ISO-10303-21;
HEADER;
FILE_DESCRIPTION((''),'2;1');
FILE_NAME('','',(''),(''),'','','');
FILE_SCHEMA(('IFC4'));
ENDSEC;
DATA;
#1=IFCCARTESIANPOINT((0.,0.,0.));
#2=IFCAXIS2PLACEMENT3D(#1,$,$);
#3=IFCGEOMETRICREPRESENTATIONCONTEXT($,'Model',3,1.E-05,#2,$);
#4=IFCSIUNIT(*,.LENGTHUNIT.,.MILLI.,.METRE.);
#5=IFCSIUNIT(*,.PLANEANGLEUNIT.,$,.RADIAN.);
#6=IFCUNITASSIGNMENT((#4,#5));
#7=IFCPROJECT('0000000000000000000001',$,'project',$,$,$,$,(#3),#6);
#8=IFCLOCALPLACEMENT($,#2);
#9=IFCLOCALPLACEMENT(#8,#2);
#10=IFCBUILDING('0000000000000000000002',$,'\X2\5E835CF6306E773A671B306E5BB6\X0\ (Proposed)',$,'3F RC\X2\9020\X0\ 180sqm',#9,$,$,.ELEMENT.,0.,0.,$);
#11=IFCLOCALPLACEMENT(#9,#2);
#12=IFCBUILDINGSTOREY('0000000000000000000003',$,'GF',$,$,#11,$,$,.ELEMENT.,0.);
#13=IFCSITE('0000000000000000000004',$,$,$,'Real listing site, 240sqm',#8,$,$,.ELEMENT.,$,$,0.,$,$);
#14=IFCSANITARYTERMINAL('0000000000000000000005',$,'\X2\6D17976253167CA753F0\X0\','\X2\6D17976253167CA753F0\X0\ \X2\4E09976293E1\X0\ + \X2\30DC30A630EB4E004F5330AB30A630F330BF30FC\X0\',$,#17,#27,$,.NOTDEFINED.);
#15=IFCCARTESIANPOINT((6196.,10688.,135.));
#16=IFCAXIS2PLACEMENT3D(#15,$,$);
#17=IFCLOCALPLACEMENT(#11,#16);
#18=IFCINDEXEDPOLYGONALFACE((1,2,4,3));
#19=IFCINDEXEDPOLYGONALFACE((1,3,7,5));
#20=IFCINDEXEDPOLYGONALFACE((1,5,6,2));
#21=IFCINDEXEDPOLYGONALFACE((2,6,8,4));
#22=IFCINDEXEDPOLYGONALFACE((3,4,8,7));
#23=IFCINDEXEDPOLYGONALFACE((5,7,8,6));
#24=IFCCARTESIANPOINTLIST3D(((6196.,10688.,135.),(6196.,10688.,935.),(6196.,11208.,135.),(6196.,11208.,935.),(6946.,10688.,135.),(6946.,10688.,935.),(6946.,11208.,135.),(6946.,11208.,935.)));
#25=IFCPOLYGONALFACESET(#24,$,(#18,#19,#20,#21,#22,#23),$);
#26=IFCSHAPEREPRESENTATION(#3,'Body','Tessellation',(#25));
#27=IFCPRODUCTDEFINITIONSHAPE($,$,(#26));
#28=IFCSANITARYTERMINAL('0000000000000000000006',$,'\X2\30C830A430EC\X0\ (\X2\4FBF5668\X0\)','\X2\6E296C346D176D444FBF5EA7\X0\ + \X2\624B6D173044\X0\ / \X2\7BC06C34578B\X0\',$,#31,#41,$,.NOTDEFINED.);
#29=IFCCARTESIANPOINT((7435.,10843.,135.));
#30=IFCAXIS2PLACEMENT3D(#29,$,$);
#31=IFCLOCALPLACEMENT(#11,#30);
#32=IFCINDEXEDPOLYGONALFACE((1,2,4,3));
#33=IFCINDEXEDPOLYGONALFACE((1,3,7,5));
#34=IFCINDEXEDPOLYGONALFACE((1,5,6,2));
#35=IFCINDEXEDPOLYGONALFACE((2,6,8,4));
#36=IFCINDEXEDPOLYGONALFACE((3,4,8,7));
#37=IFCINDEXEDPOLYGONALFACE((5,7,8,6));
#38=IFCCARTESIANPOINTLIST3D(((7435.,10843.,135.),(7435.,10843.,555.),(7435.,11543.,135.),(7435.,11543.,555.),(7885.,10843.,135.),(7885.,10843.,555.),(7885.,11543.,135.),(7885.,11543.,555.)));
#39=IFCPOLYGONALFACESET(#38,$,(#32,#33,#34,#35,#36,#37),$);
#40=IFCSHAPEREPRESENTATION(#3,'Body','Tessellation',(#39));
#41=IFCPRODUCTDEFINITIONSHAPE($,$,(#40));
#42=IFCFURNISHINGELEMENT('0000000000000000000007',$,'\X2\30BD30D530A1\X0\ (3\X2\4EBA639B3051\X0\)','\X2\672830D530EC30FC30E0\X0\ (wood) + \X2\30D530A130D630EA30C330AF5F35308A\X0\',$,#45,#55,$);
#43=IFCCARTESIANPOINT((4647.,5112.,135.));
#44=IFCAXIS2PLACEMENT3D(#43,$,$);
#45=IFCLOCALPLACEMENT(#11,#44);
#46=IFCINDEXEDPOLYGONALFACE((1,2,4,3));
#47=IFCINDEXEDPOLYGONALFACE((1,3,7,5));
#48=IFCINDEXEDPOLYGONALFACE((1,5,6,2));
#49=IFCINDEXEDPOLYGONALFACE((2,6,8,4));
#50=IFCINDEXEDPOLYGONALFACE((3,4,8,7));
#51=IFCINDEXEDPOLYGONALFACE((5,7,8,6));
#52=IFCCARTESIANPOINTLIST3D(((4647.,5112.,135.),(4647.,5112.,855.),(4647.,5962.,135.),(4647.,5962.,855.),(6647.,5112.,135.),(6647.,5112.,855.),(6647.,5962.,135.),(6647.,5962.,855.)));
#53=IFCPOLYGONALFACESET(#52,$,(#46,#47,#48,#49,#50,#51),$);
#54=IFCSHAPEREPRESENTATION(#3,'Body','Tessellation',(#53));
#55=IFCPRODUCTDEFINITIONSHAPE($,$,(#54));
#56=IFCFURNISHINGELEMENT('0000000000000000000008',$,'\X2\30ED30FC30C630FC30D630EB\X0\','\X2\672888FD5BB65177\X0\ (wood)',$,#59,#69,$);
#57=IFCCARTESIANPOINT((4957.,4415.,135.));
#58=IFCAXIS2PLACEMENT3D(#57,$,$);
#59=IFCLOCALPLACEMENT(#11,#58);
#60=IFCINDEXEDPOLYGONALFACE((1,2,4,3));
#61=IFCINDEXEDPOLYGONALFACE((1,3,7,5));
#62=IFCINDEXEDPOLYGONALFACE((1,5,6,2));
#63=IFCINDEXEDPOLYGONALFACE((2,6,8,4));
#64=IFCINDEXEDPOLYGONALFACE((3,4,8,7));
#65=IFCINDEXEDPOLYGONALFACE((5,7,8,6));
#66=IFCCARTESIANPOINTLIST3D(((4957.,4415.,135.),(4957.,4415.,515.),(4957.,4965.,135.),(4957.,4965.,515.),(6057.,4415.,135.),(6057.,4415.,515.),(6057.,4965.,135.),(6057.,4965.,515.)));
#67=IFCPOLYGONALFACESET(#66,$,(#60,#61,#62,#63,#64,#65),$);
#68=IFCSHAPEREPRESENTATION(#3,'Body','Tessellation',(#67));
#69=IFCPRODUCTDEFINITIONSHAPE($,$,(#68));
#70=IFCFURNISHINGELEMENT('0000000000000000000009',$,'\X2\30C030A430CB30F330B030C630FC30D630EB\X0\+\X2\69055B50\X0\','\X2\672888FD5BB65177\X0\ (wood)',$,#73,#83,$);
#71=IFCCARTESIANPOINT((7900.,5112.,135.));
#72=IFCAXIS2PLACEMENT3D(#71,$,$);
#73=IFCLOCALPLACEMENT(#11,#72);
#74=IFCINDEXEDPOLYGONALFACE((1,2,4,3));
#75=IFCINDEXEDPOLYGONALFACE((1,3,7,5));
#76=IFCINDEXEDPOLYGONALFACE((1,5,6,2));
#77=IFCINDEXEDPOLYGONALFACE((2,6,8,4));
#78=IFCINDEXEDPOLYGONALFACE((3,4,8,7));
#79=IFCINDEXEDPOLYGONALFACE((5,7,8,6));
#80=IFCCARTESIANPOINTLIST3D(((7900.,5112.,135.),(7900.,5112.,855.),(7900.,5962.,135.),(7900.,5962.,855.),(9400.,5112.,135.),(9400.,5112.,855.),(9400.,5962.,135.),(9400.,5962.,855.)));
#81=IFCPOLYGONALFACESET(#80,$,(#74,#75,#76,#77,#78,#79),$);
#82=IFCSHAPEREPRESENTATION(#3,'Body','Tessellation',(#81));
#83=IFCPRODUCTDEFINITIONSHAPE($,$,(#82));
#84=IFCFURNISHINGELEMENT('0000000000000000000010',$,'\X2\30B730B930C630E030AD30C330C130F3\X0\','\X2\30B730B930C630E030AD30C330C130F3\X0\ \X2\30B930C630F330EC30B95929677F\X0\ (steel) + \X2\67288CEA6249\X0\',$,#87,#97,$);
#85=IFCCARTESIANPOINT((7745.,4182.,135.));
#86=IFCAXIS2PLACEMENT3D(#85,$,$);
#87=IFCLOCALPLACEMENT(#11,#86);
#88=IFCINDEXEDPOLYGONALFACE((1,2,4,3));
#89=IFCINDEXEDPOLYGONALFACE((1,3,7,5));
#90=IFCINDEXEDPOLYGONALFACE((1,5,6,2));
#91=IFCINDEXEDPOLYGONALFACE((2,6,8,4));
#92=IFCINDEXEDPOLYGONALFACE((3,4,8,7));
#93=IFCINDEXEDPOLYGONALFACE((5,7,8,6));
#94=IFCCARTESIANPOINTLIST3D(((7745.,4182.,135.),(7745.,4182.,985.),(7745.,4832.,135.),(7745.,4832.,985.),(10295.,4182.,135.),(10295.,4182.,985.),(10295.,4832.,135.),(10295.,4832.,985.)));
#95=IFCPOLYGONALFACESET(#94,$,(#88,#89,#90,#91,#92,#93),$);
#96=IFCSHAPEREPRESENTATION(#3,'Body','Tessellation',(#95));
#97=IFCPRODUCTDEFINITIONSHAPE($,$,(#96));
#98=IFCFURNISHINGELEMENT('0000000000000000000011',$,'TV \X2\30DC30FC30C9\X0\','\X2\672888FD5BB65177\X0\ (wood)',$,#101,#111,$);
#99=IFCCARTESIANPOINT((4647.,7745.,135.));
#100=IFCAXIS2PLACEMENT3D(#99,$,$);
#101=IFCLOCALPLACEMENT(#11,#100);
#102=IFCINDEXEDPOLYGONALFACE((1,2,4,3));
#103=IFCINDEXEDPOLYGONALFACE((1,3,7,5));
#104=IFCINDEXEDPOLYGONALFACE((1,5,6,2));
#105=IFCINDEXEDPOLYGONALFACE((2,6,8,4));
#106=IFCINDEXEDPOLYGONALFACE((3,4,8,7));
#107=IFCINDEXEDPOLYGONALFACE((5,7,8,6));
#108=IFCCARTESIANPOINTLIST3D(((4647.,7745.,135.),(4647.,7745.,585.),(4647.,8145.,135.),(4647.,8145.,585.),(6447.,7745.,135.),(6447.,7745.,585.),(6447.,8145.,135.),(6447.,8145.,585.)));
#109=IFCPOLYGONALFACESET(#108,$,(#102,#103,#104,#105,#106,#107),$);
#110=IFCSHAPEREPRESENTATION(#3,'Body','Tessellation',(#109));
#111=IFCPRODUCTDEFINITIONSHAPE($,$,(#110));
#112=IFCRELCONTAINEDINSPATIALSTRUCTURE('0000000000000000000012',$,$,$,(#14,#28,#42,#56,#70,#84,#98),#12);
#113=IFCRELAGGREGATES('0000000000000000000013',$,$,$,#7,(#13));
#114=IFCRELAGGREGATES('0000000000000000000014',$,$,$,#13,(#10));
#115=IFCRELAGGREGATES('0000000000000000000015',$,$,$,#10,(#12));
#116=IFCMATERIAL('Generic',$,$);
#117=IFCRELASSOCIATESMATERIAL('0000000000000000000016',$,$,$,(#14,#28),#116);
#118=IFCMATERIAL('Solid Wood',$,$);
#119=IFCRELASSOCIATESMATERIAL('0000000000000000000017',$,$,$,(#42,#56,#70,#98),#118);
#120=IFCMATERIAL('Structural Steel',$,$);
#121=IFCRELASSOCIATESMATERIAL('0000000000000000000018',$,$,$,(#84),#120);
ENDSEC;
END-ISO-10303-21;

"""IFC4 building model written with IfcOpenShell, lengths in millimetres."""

from ifc_helpers import new_model, si_unit, frame, frame_2d, origin, place, context, project, spatial, rectangle, extrude, material, element, save


model = new_model("IFC4")

# Units and contexts
model_context = context("Model", 3, precision=1e-05, world=origin())
ifc_project = project(units=[si_unit("LENGTHUNIT", "METRE", prefix="MILLI"), si_unit("PLANEANGLEUNIT", "RADIAN")], contexts=[model_context])

# Site, building, storey
site_placement = place(None, origin())
site = spatial("IfcSite", under=ifc_project, at=site_placement, ObjectType="Real listing site, 240sqm", CompositionType="ELEMENT", RefElevation=0.0)
building_placement = place(site_placement, origin())
building = spatial("IfcBuilding", under=site, at=building_placement, Name="広島の眺望の家 (Proposed)", ObjectType="3F RC造 180sqm", CompositionType="ELEMENT", ElevationOfRefHeight=0.0, ElevationOfTerrain=0.0)
storey_placement = place(building_placement, origin())
storey = spatial("IfcBuildingStorey", under=building, at=storey_placement, Name="GF", CompositionType="ELEMENT", Elevation=0.0)

# Shared definitions
ifc_material_1 = material(Name="Solid Wood")

# Sanitary terminals
ifc_material_2 = material(Name="Generic")
sanitary_terminal_1_placement = place(storey_placement, frame((6196.0, 10688.0, 135.0)))
element("IfcSanitaryTerminal", 1, at=sanitary_terminal_1_placement, inside=storey, material=ifc_material_2, Name="洗面化粧台", Description="洗面化粧台 三面鏡 + ボウル一体カウンター", PredefinedType="NOTDEFINED", context=model_context, shape_type="SweptSolid", body=[
    extrude(rectangle(XDim=750.0, YDim=520.0, at=frame_2d((375.0, 260.0))), frame((6196.0, 10688.0, 135.0)), (0.0, 0.0, 1.0), 800.0),
])
sanitary_terminal_2_placement = place(storey_placement, frame((7435.0, 10843.0, 135.0)))
element("IfcSanitaryTerminal", 2, at=sanitary_terminal_2_placement, inside=storey, material=ifc_material_2, Name="トイレ (便器)", Description="温水洗浄便座 + 手洗い / 節水型", PredefinedType="NOTDEFINED", context=model_context, shape_type="SweptSolid", body=[
    extrude(rectangle(XDim=450.0, YDim=700.0, at=frame_2d((225.0, 350.0))), frame((7435.0, 10843.0, 135.0)), (0.0, 0.0, 1.0), 420.0),
])

# Furnishing elements
furnishing_1_placement = place(storey_placement, frame((4647.0, 5112.0, 135.0)))
element("IfcFurnishingElement", 3, at=furnishing_1_placement, inside=storey, material=ifc_material_1, Name="ソファ (3人掛け)", Description="木フレーム (wood) + ファブリック張り", context=model_context, shape_type="SweptSolid", body=[
    extrude(rectangle(XDim=2000.0, YDim=850.0, at=frame_2d((1000.0, 425.0))), frame((4647.0, 5112.0, 135.0)), (0.0, 0.0, 1.0), 720.0),
])
furnishing_2_placement = place(storey_placement, frame((4957.0, 4415.0, 135.0)))
element("IfcFurnishingElement", 4, at=furnishing_2_placement, inside=storey, material=ifc_material_1, Name="ローテーブル", Description="木製家具 (wood)", context=model_context, shape_type="SweptSolid", body=[
    extrude(rectangle(XDim=1100.0, YDim=550.0, at=frame_2d((550.0, 275.0))), frame((4957.0, 4415.0, 135.0)), (0.0, 0.0, 1.0), 380.0),
])
furnishing_3_placement = place(storey_placement, frame((7900.0, 5112.0, 135.0)))
element("IfcFurnishingElement", 5, at=furnishing_3_placement, inside=storey, material=ifc_material_1, Name="ダイニングテーブル+椅子", Description="木製家具 (wood)", context=model_context, shape_type="SweptSolid", body=[
    extrude(rectangle(XDim=1500.0, YDim=850.0, at=frame_2d((750.0, 425.0))), frame((7900.0, 5112.0, 135.0)), (0.0, 0.0, 1.0), 720.0),
])
ifc_material_3 = material(Name="Structural Steel")
furnishing_4_placement = place(storey_placement, frame((7745.0, 4182.0, 135.0)))
element("IfcFurnishingElement", 6, at=furnishing_4_placement, inside=storey, material=ifc_material_3, Name="システムキッチン", Description="システムキッチン ステンレス天板 (steel) + 木質扉", context=model_context, shape_type="SweptSolid", body=[
    extrude(rectangle(XDim=2550.0, YDim=650.0, at=frame_2d((1275.0, 325.0))), frame((7745.0, 4182.0, 135.0)), (0.0, 0.0, 1.0), 850.0),
])
furnishing_5_placement = place(storey_placement, frame((4647.0, 7745.0, 135.0)))
element("IfcFurnishingElement", 7, at=furnishing_5_placement, inside=storey, material=ifc_material_1, Name="TV ボード", Description="木製家具 (wood)", context=model_context, shape_type="SweptSolid", body=[
    extrude(rectangle(XDim=1800.0, YDim=400.0, at=frame_2d((900.0, 200.0))), frame((4647.0, 7745.0, 135.0)), (0.0, 0.0, 1.0), 450.0),
])

save(model, "model.ifc")
